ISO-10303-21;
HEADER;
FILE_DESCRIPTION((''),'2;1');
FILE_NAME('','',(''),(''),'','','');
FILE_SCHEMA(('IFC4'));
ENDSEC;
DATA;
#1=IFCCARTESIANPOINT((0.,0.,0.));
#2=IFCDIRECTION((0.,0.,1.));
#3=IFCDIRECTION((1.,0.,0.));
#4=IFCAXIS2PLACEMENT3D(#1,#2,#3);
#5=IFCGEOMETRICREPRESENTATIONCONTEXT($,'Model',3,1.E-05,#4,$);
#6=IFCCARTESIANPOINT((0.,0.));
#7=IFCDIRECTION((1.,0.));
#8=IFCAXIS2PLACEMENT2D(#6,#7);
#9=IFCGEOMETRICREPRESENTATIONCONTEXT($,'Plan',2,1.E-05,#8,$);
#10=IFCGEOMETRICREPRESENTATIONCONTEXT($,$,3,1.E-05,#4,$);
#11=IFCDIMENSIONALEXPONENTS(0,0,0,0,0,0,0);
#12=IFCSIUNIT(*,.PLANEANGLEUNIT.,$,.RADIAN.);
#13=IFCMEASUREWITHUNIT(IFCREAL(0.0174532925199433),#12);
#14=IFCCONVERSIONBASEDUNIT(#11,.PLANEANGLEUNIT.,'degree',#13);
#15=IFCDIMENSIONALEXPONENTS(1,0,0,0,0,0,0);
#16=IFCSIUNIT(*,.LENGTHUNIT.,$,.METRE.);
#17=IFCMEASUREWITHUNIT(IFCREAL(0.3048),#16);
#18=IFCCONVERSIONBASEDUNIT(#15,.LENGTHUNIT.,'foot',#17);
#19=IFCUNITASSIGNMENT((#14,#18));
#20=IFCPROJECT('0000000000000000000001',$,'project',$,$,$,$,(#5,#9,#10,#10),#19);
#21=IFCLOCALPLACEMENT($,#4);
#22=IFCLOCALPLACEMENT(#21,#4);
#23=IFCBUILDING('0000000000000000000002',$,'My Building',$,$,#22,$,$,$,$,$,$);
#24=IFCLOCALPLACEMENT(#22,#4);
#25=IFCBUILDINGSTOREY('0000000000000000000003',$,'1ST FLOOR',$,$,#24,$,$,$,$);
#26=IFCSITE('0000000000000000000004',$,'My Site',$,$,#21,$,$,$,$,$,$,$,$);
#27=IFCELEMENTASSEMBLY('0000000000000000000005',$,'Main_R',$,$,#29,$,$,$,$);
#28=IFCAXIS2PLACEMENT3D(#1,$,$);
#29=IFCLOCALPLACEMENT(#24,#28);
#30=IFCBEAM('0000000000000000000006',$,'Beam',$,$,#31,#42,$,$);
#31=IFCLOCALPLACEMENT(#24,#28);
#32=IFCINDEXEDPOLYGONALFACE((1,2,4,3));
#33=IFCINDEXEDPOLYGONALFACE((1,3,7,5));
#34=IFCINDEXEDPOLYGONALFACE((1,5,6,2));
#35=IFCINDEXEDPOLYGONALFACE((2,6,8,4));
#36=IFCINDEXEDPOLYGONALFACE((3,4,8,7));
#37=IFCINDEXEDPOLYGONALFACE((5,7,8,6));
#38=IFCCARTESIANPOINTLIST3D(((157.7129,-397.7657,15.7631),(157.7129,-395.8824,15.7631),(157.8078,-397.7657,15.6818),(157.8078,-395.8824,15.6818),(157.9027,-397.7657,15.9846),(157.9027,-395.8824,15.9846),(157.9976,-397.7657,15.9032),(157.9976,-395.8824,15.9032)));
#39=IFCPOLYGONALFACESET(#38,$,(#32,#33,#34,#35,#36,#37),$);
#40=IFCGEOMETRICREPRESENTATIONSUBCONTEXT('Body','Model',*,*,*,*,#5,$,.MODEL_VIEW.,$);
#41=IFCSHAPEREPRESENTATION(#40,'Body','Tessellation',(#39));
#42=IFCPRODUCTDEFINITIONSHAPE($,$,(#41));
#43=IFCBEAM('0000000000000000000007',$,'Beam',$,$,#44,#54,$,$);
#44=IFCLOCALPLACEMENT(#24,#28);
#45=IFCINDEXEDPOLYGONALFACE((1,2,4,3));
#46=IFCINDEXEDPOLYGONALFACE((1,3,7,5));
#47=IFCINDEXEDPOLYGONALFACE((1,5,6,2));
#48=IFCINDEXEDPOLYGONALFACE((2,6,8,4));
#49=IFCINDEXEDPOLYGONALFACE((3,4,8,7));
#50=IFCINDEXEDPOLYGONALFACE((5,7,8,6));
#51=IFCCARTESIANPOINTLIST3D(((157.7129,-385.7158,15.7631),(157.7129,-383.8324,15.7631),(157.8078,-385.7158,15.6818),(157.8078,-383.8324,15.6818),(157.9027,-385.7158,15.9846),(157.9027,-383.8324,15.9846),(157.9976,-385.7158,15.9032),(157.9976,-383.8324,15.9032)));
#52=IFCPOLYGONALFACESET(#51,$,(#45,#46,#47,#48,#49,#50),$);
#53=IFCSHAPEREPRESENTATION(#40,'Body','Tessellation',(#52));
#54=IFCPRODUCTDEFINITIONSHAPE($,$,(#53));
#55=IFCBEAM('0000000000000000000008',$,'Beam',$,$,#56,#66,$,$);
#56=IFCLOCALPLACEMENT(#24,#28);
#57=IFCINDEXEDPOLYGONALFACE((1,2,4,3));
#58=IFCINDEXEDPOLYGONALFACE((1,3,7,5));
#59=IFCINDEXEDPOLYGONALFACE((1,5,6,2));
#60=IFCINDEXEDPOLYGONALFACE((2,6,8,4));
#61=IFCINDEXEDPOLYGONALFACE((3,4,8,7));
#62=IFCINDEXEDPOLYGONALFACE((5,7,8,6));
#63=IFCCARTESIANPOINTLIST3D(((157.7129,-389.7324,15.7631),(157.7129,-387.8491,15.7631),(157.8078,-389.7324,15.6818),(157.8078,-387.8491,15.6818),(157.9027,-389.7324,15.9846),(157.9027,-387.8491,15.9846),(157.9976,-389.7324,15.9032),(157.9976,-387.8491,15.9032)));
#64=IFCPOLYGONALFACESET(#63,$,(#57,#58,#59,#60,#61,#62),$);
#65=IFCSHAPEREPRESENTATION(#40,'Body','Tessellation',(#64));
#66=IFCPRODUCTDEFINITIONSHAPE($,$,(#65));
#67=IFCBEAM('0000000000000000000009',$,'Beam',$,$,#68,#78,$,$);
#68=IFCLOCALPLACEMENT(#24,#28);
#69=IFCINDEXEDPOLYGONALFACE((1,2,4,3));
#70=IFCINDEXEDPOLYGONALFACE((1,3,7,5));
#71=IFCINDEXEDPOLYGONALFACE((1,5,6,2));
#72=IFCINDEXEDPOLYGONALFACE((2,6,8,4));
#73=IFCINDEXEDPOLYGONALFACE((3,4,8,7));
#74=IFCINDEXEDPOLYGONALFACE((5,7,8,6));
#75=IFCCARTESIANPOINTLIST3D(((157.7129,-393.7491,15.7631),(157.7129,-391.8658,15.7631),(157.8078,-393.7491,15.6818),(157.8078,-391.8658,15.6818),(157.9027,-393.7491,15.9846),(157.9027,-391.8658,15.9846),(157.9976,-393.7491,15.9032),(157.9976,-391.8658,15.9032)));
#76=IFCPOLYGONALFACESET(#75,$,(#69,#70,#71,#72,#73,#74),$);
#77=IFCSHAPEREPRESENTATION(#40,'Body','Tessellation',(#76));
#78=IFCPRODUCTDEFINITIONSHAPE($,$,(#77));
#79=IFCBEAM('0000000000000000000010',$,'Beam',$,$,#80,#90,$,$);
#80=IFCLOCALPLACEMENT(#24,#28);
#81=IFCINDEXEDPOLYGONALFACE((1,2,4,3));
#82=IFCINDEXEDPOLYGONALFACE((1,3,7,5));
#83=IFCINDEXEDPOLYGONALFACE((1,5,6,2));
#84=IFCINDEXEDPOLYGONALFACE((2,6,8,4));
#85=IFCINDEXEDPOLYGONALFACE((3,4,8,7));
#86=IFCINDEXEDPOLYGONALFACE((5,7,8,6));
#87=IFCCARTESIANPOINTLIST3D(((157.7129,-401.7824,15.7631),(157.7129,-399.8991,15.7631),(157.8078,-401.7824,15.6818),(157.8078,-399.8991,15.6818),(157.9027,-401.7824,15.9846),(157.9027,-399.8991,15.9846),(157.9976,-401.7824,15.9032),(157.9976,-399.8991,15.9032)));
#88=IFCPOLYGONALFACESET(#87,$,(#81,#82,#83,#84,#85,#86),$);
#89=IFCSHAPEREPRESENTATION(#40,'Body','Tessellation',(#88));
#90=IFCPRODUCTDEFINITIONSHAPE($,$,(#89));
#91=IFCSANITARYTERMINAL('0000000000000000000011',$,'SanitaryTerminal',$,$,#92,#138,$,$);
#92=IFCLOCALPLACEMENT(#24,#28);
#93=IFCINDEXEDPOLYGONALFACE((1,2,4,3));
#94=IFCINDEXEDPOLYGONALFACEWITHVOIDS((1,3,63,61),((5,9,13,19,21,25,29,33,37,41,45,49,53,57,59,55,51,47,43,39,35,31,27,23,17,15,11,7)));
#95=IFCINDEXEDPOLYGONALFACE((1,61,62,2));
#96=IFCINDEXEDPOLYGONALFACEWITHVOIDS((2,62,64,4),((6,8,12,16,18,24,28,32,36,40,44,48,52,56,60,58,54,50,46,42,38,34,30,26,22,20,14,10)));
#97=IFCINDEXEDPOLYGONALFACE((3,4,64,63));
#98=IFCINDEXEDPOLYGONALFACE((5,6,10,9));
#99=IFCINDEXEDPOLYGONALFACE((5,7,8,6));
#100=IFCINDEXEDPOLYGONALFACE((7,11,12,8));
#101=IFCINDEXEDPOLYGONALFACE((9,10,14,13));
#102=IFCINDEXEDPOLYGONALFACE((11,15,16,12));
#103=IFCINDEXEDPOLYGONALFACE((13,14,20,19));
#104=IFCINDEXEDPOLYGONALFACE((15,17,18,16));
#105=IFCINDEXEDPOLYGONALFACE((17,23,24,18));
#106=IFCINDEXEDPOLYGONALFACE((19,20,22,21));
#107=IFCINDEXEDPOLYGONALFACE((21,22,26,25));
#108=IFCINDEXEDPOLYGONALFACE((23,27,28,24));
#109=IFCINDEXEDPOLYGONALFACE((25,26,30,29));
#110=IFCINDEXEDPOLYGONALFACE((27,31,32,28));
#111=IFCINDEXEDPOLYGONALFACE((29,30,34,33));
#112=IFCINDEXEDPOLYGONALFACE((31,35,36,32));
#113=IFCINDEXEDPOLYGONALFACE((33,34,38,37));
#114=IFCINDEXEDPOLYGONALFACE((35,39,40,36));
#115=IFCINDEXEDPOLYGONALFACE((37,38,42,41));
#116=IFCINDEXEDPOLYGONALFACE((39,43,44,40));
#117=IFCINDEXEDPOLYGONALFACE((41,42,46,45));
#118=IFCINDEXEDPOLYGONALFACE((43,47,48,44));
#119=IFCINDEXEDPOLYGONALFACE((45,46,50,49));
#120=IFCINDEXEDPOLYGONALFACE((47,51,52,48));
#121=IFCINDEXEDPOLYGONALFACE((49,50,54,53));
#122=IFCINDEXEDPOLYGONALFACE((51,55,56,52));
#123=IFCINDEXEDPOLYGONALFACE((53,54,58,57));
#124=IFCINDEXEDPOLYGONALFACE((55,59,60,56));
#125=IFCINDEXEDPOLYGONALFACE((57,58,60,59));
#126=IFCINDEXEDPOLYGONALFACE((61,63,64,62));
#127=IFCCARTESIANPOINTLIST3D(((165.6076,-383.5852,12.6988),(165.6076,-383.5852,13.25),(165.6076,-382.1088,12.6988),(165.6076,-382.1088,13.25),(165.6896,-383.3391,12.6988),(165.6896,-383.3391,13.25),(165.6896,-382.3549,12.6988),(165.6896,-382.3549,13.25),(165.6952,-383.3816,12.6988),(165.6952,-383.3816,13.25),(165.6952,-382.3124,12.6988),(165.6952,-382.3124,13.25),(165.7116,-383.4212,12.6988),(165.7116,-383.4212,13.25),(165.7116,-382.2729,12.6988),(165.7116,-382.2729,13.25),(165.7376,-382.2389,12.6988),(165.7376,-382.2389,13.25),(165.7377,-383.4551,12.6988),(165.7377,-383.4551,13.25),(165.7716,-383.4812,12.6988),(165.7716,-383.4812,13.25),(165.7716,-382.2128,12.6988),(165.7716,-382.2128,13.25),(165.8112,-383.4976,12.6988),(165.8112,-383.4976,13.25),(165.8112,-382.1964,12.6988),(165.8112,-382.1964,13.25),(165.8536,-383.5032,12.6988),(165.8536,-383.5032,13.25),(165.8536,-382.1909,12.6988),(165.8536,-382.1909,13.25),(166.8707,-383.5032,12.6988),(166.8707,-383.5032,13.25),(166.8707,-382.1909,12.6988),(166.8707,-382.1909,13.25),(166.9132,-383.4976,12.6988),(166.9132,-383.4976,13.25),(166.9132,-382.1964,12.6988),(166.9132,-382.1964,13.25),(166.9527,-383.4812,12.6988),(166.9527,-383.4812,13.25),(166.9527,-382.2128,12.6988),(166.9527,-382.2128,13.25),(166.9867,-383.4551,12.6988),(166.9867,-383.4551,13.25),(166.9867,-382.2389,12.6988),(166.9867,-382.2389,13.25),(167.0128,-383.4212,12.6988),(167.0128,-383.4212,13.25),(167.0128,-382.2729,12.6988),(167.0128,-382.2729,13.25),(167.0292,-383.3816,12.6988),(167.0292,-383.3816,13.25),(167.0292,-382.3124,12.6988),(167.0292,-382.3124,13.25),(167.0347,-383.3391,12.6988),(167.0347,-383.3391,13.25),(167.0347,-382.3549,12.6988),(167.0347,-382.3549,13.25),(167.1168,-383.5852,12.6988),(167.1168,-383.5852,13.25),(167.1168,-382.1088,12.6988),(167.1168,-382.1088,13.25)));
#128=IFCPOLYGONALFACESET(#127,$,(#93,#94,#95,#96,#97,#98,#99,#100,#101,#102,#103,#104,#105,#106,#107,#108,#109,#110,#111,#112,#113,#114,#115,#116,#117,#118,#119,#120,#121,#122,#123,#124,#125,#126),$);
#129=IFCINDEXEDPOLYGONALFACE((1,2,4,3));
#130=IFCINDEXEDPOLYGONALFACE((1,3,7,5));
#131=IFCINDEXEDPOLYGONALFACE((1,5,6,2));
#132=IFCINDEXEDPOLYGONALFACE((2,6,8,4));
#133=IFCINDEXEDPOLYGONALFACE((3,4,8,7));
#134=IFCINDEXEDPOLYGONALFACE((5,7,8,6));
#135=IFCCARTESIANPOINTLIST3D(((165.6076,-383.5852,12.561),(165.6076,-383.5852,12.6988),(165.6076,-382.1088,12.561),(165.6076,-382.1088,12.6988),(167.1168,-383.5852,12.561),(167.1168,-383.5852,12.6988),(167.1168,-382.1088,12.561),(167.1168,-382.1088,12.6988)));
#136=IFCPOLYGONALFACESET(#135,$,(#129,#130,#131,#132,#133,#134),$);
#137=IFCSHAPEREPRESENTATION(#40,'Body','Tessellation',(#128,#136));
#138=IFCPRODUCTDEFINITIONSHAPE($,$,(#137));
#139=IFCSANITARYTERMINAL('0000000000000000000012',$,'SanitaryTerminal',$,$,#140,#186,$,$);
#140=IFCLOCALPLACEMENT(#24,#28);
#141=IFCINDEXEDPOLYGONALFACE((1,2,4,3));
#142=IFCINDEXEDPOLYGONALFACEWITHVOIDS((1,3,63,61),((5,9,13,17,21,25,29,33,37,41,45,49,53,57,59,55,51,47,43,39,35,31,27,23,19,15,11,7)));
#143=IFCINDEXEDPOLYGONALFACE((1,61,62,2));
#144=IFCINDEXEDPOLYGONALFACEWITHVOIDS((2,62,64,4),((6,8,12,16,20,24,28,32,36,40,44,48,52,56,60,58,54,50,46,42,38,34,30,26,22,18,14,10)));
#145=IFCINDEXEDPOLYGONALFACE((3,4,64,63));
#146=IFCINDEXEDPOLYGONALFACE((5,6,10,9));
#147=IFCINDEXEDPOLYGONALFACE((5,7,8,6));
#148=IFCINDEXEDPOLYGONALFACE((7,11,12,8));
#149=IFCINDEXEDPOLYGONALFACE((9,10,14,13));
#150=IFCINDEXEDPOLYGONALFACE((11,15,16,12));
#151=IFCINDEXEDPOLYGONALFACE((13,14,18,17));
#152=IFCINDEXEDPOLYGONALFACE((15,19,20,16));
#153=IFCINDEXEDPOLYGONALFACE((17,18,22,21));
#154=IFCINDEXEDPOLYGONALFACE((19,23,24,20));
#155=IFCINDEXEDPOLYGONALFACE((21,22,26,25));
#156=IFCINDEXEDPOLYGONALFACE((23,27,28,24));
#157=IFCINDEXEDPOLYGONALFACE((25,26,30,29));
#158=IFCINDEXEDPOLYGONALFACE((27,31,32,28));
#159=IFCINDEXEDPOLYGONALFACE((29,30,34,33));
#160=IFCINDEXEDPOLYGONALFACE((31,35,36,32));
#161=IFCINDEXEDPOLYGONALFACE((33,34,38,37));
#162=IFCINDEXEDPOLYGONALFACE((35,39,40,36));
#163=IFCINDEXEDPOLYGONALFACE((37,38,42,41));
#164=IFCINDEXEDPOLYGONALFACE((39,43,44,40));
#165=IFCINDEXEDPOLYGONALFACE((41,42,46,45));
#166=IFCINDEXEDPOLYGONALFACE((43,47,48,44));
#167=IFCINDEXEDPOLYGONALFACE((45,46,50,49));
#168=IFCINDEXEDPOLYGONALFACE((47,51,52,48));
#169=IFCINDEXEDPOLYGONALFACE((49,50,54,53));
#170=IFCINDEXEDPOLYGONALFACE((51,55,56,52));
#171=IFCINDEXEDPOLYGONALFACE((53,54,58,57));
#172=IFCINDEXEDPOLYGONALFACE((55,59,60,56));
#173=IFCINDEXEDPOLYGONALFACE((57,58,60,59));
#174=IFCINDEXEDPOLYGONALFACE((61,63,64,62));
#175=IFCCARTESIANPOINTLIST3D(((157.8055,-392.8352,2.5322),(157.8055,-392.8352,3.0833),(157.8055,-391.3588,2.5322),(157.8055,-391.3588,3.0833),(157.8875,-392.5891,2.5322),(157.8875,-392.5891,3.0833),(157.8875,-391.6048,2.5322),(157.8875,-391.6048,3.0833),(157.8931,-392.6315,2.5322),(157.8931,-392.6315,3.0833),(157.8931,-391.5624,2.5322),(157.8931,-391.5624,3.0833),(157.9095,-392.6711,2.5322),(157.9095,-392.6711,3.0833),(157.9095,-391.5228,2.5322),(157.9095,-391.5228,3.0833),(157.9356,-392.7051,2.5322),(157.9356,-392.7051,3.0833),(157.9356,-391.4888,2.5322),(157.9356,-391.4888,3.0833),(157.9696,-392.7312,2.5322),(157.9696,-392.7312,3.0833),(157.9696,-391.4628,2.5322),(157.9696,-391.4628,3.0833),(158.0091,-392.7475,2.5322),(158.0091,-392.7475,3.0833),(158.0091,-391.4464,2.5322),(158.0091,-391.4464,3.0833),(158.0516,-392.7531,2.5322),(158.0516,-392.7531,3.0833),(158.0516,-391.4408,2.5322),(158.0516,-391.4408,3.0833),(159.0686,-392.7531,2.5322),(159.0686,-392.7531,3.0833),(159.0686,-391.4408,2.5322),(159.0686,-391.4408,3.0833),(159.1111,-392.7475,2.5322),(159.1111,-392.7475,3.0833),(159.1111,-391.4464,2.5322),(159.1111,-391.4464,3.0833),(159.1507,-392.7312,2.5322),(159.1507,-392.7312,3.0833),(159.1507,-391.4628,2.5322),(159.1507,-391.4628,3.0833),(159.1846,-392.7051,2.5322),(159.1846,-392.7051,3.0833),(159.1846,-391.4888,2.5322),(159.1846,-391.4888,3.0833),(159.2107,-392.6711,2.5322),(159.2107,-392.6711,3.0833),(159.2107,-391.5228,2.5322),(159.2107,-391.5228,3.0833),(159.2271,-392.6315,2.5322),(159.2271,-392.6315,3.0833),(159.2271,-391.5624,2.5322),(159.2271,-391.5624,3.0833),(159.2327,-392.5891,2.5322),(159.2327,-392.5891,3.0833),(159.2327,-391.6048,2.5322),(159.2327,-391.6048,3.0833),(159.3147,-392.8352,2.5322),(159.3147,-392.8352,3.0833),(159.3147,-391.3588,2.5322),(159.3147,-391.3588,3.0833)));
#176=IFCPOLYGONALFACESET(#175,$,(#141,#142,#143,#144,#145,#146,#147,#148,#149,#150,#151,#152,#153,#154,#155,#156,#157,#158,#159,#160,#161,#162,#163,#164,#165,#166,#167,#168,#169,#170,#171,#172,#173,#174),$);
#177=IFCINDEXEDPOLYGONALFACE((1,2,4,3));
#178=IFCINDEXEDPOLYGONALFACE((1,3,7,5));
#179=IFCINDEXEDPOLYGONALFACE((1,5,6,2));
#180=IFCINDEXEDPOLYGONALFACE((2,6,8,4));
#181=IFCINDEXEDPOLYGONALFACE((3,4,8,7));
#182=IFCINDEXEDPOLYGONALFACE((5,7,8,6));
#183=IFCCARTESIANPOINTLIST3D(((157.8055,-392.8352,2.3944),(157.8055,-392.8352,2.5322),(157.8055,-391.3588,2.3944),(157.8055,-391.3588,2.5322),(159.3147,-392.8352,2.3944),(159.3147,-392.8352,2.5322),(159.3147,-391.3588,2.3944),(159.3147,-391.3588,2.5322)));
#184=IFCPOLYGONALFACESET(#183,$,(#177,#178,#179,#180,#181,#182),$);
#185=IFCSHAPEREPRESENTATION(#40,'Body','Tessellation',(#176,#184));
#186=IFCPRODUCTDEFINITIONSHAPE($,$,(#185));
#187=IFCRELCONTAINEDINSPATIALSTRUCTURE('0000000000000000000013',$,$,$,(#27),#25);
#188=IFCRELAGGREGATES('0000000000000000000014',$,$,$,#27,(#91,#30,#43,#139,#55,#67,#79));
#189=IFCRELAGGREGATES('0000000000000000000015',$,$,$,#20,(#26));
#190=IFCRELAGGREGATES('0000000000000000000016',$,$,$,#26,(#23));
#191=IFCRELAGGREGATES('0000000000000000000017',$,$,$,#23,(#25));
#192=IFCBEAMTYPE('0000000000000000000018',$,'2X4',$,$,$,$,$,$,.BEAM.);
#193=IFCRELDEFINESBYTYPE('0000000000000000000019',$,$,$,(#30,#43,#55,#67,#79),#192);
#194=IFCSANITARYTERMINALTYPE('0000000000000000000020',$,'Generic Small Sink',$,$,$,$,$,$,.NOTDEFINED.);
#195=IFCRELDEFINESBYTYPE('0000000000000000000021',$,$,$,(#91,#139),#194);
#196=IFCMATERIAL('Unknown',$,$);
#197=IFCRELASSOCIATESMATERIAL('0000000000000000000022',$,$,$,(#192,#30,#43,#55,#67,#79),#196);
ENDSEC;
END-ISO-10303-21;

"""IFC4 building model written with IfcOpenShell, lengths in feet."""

from ifc_helpers import new_model, entity, si_unit, converted_unit, frame, origin_with_axes, origin_2d_with_axis, place, context, subcontext, project, spatial, rectangle, extrude, source, transform, mapped, material, material_profile, profile_set, profile_usage, type_object, type_shapes, element, aggregate, save


model = new_model("IFC4")

# Units and contexts
model_context = context("Model", 3, precision=1e-05, world=origin_with_axes())
plan_context = context("Plan", 2, precision=1e-05, world=origin_2d_with_axis())
context_of_model = context(None, 3, precision=1e-05, world=origin_with_axes())
body_context = subcontext(model_context, "Body", "Model", "MODEL_VIEW")
ifc_project = project(units=[converted_unit("PLANEANGLEUNIT", "degree", entity("IfcReal", 0.0174532925199433), si_unit("PLANEANGLEUNIT", "RADIAN"), dimensions=[0, 0, 0, 0, 0, 0, 0]), converted_unit("LENGTHUNIT", "foot", entity("IfcReal", 0.3048), si_unit("LENGTHUNIT", "METRE"), dimensions=[1, 0, 0, 0, 0, 0, 0])], contexts=[model_context, plan_context, context_of_model, context_of_model])

# Site, building, storey
site_placement = place(None, origin_with_axes())
site = spatial("IfcSite", under=ifc_project, at=site_placement, Name="My Site")
building_placement = place(site_placement, origin_with_axes())
building = spatial("IfcBuilding", under=site, at=building_placement, Name="My Building")
storey_placement = place(building_placement, origin_with_axes())
storey = spatial("IfcBuildingStorey", under=building, at=storey_placement, Name="1ST FLOOR")

# Element assembly, beams
assembly_1_placement = place(storey_placement, origin_with_axes())
assembly_1 = element("IfcElementAssembly", 1, at=assembly_1_placement, inside=storey, Name="Main_R")
ifc_material_1 = material(Name="Unknown")
ifc_material_profile_1 = material_profile(ifc_material_1, rectangle(XDim=0.125, YDim=0.2917))
ifc_profile_set_1 = profile_set([ifc_material_profile_1])
ifc_profile_usage_1 = profile_usage(ifc_profile_set_1, cardinal=5)
beam_type_1 = type_object("IfcBeamType", Name="2X4", PredefinedType="BEAM", material=ifc_profile_set_1)
beam_1_placement = place(assembly_1_placement, frame((157.8553, -395.8824, 15.8332), z_axis=(0.0, -1.0, 0.0), x_axis=(-0.759271, 0.0, 0.650774)))
beam_1 = element("IfcBeam", 2, at=beam_1_placement, type_object=beam_type_1, material=ifc_profile_usage_1, Name="Beam", context=body_context, shape_type="SweptSolid", body=[
    extrude(rectangle(XDim=0.125, YDim=0.2917), origin_with_axes(), (0.0, 0.0, 1.0), 1.8833),
])
ifc_profile_usage_2 = profile_usage(ifc_profile_set_1, cardinal=5)
beam_2_placement = place(assembly_1_placement, frame((157.8553, -383.8324, 15.8332), z_axis=(0.0, -1.0, 0.0), x_axis=(-0.759271, 0.0, 0.650774)))
beam_2 = element("IfcBeam", 3, at=beam_2_placement, type_object=beam_type_1, material=ifc_profile_usage_2, Name="Beam", context=body_context, shape_type="SweptSolid", body=[
    extrude(rectangle(XDim=0.125, YDim=0.2917), origin_with_axes(), (0.0, 0.0, 1.0), 1.8833),
])
ifc_profile_usage_3 = profile_usage(ifc_profile_set_1, cardinal=5)
beam_3_placement = place(assembly_1_placement, frame((157.8553, -387.8491, 15.8332), z_axis=(0.0, -1.0, 0.0), x_axis=(-0.759271, 0.0, 0.650774)))
beam_3 = element("IfcBeam", 4, at=beam_3_placement, type_object=beam_type_1, material=ifc_profile_usage_3, Name="Beam", context=body_context, shape_type="SweptSolid", body=[
    extrude(rectangle(XDim=0.125, YDim=0.2917), origin_with_axes(), (0.0, 0.0, 1.0), 1.8833),
])
ifc_profile_usage_4 = profile_usage(ifc_profile_set_1, cardinal=5)
beam_4_placement = place(assembly_1_placement, frame((157.8553, -391.8658, 15.8332), z_axis=(0.0, -1.0, 0.0), x_axis=(-0.759271, 0.0, 0.650774)))
beam_4 = element("IfcBeam", 5, at=beam_4_placement, type_object=beam_type_1, material=ifc_profile_usage_4, Name="Beam", context=body_context, shape_type="SweptSolid", body=[
    extrude(rectangle(XDim=0.125, YDim=0.2917), origin_with_axes(), (0.0, 0.0, 1.0), 1.8833),
])
ifc_profile_usage_5 = profile_usage(ifc_profile_set_1, cardinal=5)
beam_5_placement = place(assembly_1_placement, frame((157.8553, -399.8991, 15.8332), z_axis=(0.0, -1.0, 0.0), x_axis=(-0.759271, 0.0, 0.650774)))
beam_5 = element("IfcBeam", 6, at=beam_5_placement, type_object=beam_type_1, material=ifc_profile_usage_5, Name="Beam", context=body_context, shape_type="SweptSolid", body=[
    extrude(rectangle(XDim=0.125, YDim=0.2917), origin_with_axes(), (0.0, 0.0, 1.0), 1.8833),
])

# Sanitary terminals
sanitary_terminal_type = type_object("IfcSanitaryTerminalType", Name="Generic Small Sink", PredefinedType="NOTDEFINED")
shared_indexed_poly_curve = entity("IfcIndexedPolyCurve", entity("IfcCartesianPointList2D", [[0.0, 0.0], [1.4764, 0.0], [1.4764, 1.5092], [0.0, 1.5092]]), [entity("IfcLineIndex", [1, 2, 3, 4, 1])])
shared_shape_1 = source(origin_with_axes(), body_context, "Body", "SweptSolid", [
    entity("IfcExtrudedAreaSolid", entity("IfcArbitraryProfileDefWithVoids", "AREA", None, shared_indexed_poly_curve, [entity("IfcIndexedPolyCurve", entity("IfcCartesianPointList2D", [[0.082, 0.2461], [0.1301, 0.1301], [0.2461, 0.082], [1.2303, 0.082], [1.3463, 0.1301], [1.3944, 0.2461], [1.3944, 1.2631], [1.3463, 1.3791], [1.2303, 1.4272], [0.2461, 1.4272], [0.1301, 1.3791], [0.082, 1.2631]]), [entity("IfcLineIndex", [12, 1]), entity("IfcArcIndex", [1, 2, 3]), entity("IfcLineIndex", [3, 4]), entity("IfcArcIndex", [4, 5, 6]), entity("IfcLineIndex", [6, 7]), entity("IfcArcIndex", [7, 8, 9]), entity("IfcLineIndex", [9, 10]), entity("IfcArcIndex", [10, 11, 12]), entity("IfcLineIndex", [12, 1])])]), entity("IfcAxis2Placement3D", entity("IfcCartesianPoint", [-0.7382, -1.5092, 0.1378]), entity("IfcDirection", [0.0, 0.0, 1.0]), entity("IfcDirection", [1.0, 0.0, 0.0])), entity("IfcDirection", [0.0, 0.0, 1.0]), 0.5512),
    entity("IfcExtrudedAreaSolid", entity("IfcArbitraryClosedProfileDef", "AREA", None, shared_indexed_poly_curve), entity("IfcAxis2Placement3D", entity("IfcCartesianPoint", [-0.7382, -1.5092, 0.0]), entity("IfcDirection", [0.0, 0.0, 1.0]), entity("IfcDirection", [1.0, 0.0, 0.0])), entity("IfcDirection", [0.0, 0.0, 1.0]), 0.1378),
])
type_shapes(sanitary_terminal_type, [shared_shape_1])
sanitary_terminal_1_placement = place(assembly_1_placement, frame((167.1168, -382.847, 12.561), z_axis=(0.0, 0.0, 1.0), x_axis=(0.0, -1.0, 0.0)))
sanitary_terminal_1 = element("IfcSanitaryTerminal", 7, at=sanitary_terminal_1_placement, type_object=sanitary_terminal_type, Name="SanitaryTerminal", context=body_context, shape_type="MappedRepresentation", body=[
    mapped(shared_shape_1, transform((0.0, 0.0, 0.0), x_axis=(1.0, 0.0, 0.0), y_axis=(0.0, 1.0, 0.0), z_axis=(0.0, 0.0, 1.0), scale=1.0)),
])
sanitary_terminal_2_placement = place(assembly_1_placement, frame((159.3147, -392.097, 2.3944), z_axis=(0.0, 0.0, 1.0), x_axis=(0.0, -1.0, 0.0)))
sanitary_terminal_2 = element("IfcSanitaryTerminal", 8, at=sanitary_terminal_2_placement, type_object=sanitary_terminal_type, Name="SanitaryTerminal", context=body_context, shape_type="MappedRepresentation", body=[
    mapped(shared_shape_1, transform((0.0, 0.0, 0.0), x_axis=(1.0, 0.0, 0.0), y_axis=(0.0, 1.0, 0.0), z_axis=(0.0, 0.0, 1.0), scale=1.0)),
])

aggregate(assembly_1, [sanitary_terminal_1, beam_1, beam_2, sanitary_terminal_2, beam_3, beam_4, beam_5])

save(model, "model.ifc")
